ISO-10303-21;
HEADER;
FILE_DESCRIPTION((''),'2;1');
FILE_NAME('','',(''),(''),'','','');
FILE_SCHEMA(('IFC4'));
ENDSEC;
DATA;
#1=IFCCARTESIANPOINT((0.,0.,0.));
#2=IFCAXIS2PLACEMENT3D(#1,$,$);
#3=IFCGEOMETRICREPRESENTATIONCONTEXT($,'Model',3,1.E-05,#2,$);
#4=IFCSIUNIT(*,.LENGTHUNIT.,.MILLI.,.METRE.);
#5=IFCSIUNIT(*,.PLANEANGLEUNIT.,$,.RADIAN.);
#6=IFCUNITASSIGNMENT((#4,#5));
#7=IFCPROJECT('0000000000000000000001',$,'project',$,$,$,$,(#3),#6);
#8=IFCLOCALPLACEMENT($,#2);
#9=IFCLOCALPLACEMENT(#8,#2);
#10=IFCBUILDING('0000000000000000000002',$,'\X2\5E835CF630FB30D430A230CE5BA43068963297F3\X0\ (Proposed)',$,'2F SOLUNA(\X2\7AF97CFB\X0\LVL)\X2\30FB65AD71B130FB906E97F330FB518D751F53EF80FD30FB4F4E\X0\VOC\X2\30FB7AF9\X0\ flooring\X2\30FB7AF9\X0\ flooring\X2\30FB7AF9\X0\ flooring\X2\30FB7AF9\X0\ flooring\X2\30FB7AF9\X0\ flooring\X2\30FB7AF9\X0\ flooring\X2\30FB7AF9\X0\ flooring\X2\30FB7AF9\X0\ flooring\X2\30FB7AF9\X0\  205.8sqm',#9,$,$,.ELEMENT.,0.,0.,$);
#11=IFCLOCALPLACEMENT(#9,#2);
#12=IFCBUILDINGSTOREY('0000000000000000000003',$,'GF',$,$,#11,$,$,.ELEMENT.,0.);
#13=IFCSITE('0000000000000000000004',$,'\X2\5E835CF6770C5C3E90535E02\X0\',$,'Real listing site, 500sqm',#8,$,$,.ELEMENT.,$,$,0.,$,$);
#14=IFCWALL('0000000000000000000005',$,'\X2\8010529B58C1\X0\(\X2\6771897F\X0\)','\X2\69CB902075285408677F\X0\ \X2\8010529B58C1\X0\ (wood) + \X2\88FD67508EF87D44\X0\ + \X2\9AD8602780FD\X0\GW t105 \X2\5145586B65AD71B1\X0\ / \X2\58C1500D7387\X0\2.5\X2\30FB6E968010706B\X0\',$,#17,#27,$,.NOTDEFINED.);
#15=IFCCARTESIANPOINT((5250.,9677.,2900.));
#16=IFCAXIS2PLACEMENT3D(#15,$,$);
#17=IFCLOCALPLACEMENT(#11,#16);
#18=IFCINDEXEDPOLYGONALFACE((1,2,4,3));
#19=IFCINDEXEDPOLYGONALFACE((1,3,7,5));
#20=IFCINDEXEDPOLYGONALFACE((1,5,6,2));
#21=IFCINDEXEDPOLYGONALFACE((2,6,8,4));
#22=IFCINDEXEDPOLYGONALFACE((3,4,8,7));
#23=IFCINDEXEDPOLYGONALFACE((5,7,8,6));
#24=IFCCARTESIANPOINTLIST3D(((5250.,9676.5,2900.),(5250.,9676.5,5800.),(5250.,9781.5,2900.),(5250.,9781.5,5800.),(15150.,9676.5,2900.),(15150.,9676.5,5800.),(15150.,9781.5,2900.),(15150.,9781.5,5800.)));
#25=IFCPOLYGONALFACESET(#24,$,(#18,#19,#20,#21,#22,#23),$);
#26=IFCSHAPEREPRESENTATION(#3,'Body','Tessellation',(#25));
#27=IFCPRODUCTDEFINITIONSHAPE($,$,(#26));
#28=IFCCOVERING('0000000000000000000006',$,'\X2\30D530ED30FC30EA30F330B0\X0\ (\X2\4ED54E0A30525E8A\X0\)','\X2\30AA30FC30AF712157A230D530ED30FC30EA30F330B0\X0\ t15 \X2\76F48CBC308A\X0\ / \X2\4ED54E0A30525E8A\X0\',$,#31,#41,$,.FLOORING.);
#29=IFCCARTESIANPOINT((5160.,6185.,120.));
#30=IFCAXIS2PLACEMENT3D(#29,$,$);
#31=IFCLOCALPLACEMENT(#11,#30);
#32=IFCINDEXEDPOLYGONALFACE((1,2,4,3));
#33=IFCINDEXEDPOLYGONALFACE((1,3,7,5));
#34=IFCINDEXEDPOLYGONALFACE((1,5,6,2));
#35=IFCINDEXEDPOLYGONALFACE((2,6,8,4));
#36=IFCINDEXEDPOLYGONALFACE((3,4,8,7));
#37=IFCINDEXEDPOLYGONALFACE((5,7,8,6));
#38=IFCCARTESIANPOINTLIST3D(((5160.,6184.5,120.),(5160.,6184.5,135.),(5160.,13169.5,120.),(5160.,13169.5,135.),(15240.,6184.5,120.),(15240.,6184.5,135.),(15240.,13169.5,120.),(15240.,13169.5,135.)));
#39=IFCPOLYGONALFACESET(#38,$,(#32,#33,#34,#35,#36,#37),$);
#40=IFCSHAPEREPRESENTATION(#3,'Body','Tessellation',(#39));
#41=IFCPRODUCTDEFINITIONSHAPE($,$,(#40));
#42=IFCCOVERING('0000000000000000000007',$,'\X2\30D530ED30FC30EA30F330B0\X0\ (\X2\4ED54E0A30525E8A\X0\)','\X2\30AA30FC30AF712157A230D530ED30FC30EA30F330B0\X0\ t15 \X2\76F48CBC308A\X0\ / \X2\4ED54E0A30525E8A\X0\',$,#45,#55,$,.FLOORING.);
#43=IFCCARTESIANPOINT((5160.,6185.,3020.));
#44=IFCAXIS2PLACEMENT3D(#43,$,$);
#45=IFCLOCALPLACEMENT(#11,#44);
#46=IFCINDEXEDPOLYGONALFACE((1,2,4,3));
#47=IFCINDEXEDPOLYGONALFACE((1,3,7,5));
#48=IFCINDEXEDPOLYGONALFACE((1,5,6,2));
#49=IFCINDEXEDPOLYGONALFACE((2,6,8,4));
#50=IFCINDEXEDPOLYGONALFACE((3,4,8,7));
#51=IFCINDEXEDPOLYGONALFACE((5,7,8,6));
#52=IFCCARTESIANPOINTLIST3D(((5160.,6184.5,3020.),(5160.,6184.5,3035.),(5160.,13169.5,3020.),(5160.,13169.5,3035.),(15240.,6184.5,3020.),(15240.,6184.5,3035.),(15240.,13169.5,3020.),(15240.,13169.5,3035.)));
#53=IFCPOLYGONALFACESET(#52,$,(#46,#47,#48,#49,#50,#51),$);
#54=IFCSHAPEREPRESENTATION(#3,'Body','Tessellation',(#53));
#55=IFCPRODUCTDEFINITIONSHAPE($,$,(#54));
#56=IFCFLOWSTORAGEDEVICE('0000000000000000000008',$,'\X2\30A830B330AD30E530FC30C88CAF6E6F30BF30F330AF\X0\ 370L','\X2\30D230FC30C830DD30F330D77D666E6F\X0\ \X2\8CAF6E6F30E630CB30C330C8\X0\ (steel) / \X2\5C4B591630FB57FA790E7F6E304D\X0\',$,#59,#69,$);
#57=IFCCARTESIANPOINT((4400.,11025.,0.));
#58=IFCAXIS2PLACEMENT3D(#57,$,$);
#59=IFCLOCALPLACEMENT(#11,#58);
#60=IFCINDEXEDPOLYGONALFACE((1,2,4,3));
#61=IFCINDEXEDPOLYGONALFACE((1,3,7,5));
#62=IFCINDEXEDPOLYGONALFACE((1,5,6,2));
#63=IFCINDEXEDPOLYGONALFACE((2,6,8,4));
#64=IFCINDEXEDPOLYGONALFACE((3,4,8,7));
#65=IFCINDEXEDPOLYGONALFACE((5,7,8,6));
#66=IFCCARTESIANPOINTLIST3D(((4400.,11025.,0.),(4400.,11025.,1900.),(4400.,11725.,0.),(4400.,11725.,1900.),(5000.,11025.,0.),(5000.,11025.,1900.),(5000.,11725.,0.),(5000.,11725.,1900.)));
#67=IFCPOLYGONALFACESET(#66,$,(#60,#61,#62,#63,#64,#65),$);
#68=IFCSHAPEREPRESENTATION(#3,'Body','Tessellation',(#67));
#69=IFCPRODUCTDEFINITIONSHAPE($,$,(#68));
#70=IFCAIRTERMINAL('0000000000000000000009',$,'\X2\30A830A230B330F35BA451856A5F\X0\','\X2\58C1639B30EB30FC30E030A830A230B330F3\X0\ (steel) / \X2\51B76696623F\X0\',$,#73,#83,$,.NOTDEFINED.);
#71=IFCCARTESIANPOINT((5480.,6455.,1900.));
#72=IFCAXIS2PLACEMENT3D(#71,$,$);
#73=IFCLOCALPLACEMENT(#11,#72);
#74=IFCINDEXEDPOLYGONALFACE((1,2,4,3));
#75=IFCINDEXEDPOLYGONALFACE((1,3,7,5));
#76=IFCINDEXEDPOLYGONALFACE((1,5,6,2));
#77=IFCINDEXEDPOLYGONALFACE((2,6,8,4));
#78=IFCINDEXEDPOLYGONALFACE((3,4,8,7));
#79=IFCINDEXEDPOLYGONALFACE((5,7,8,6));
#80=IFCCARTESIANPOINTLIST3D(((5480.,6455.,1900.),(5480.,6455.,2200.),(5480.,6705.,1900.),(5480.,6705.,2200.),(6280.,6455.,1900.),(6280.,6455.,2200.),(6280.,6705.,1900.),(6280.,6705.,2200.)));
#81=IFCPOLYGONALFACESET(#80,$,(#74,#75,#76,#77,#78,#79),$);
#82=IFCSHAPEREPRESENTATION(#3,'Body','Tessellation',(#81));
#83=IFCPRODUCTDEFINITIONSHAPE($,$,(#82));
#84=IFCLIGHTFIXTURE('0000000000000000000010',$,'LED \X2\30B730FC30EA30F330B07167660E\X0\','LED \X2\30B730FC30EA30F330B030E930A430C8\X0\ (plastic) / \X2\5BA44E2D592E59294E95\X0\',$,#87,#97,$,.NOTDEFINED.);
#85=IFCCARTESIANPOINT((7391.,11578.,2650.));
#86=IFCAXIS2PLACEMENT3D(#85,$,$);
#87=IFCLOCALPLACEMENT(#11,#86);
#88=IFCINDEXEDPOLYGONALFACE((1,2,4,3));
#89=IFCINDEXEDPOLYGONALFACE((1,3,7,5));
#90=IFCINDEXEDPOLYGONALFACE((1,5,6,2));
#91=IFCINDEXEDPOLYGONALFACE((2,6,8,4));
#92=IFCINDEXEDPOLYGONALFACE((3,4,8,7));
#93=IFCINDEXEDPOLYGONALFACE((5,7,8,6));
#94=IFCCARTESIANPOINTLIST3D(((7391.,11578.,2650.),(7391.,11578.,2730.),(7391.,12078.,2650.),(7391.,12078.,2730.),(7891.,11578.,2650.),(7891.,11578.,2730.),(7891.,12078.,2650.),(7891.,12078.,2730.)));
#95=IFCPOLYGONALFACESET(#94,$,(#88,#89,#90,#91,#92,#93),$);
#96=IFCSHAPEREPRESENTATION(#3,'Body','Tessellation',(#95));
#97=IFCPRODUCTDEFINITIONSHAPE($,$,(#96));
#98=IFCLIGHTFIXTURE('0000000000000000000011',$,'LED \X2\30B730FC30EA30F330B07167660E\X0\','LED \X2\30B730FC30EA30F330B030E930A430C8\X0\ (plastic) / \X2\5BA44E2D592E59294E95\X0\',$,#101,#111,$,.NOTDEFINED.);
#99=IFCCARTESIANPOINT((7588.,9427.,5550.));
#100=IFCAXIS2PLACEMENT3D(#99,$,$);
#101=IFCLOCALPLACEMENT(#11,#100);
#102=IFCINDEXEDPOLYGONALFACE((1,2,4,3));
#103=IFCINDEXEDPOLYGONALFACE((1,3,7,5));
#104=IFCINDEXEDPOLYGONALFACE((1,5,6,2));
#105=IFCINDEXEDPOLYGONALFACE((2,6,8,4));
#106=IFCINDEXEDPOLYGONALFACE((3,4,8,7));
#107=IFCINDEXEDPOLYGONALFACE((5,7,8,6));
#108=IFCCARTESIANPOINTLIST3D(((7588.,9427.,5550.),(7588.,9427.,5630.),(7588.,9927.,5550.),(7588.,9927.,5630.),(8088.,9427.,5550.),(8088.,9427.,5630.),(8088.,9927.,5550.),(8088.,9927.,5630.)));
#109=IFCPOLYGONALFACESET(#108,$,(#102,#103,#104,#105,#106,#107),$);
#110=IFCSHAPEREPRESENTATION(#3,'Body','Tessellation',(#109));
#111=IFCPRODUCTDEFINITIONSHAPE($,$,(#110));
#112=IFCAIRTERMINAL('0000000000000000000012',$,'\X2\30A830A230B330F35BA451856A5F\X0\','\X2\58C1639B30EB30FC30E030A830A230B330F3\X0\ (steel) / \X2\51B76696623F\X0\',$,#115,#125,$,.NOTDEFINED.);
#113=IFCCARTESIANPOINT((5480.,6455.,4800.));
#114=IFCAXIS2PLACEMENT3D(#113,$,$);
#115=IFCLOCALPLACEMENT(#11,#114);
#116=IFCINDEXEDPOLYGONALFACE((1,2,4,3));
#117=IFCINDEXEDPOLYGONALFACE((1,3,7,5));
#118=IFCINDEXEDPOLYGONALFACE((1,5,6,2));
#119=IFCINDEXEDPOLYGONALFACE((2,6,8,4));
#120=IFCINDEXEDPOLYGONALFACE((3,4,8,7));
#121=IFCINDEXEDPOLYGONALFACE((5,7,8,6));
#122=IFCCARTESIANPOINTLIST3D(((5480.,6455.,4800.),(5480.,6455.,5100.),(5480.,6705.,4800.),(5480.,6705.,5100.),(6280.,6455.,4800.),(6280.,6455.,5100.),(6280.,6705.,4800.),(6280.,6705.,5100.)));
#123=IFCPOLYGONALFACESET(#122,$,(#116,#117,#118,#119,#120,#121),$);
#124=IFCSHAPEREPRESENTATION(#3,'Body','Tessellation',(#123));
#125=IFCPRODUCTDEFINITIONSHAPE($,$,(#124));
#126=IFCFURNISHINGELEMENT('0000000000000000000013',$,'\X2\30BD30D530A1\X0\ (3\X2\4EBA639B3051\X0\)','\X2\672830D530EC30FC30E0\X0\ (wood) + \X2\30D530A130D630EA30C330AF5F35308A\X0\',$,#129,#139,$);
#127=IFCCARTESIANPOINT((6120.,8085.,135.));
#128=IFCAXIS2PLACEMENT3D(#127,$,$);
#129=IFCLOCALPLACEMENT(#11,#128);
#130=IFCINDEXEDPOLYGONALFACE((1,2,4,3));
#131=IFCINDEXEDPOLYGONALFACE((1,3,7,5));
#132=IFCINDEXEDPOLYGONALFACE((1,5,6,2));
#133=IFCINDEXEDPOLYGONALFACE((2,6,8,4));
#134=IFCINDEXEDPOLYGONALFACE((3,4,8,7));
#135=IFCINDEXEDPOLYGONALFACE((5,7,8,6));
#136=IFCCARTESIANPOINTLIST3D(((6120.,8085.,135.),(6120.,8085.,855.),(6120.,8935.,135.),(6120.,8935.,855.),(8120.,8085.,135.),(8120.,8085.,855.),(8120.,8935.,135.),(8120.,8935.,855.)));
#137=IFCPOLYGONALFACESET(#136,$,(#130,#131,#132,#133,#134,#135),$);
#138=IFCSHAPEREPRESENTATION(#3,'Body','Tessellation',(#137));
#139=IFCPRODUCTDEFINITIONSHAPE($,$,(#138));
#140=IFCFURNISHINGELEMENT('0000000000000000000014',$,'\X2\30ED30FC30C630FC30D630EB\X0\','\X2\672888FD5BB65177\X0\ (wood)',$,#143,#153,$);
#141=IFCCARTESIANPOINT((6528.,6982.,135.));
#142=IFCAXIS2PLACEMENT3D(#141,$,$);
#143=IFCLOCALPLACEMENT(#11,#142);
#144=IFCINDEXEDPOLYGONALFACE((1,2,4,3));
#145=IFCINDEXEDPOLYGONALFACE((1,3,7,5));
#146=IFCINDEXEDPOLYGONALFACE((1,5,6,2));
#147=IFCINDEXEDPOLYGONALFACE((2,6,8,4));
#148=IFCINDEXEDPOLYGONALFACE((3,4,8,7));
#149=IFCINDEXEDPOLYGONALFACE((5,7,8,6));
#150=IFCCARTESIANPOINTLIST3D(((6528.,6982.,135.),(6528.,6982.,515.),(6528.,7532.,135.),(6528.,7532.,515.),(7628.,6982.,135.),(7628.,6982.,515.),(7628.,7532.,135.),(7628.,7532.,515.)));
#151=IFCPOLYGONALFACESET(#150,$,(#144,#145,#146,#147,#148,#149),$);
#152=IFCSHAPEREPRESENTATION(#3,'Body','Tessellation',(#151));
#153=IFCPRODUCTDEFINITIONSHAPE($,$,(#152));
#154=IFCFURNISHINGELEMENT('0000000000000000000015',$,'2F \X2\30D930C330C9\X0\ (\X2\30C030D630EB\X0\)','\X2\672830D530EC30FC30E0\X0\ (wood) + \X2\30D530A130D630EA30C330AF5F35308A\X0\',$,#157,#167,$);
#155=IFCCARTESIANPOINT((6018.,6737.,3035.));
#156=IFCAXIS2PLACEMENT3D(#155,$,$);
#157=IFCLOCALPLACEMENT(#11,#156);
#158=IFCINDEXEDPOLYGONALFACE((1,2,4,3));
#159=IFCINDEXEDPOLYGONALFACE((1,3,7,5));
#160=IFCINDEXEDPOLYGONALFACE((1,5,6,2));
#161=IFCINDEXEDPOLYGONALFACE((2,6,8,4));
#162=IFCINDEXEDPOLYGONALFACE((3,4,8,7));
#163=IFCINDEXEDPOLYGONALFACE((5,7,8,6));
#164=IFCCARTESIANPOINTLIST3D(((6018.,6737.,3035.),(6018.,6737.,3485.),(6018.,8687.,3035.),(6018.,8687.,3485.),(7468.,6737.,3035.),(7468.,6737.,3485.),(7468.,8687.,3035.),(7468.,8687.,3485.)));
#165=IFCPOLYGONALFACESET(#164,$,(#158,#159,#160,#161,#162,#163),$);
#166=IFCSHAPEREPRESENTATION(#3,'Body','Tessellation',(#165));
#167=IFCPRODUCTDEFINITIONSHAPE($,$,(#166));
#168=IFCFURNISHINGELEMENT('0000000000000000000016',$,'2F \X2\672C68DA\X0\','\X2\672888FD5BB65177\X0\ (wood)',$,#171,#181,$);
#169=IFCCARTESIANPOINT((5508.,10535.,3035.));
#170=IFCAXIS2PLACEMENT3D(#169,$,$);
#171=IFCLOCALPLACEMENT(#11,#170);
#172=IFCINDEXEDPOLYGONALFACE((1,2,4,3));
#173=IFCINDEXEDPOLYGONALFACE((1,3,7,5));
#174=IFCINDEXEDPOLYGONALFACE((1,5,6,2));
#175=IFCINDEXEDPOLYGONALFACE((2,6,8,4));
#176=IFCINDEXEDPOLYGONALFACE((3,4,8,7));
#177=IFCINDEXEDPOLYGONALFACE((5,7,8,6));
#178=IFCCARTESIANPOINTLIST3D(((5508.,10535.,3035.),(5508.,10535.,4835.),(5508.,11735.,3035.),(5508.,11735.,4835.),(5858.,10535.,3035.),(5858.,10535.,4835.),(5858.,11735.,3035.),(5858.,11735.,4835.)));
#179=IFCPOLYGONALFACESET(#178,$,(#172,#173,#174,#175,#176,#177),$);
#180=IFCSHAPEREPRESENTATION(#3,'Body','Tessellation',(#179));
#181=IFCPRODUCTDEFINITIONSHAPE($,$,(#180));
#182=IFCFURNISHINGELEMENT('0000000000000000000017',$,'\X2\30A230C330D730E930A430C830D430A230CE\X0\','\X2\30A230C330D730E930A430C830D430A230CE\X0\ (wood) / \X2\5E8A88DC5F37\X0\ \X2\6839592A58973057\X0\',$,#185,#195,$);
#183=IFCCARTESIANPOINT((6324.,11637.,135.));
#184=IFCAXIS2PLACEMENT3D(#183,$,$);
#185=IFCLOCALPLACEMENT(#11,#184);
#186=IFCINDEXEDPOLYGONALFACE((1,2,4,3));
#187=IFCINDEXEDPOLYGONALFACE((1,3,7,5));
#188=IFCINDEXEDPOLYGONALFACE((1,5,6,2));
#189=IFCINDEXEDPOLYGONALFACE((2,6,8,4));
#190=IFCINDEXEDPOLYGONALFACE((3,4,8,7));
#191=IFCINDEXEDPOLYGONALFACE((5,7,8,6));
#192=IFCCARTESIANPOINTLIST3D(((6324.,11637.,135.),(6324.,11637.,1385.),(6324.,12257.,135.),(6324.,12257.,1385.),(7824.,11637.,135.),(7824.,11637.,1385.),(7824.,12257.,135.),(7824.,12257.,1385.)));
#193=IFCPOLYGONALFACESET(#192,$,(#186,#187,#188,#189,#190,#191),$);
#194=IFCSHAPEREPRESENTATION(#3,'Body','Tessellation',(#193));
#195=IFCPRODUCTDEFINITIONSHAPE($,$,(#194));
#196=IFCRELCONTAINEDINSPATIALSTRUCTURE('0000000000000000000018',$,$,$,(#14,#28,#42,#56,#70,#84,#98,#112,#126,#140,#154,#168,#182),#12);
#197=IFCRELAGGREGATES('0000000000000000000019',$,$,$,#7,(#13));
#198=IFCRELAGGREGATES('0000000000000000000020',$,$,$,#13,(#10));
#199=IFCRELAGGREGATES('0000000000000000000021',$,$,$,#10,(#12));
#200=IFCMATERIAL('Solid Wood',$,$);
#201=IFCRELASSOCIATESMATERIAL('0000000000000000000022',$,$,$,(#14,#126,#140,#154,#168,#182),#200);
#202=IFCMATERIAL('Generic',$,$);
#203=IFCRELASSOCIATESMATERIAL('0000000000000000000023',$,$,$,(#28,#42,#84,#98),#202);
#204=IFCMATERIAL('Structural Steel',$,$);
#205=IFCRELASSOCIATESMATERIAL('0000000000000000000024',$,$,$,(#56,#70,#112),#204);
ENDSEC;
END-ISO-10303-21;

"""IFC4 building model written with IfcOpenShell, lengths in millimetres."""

from ifc_helpers import new_model, si_unit, frame, frame_2d, origin, place, context, project, spatial, rectangle, extrude, material, element, save


model = new_model("IFC4")

# Units and contexts
model_context = context("Model", 3, precision=1e-05, world=origin())
ifc_project = project(units=[si_unit("LENGTHUNIT", "METRE", prefix="MILLI"), si_unit("PLANEANGLEUNIT", "RADIAN")], contexts=[model_context])

# Site, building, storey
site_placement = place(None, origin())
site = spatial("IfcSite", under=ifc_project, at=site_placement, Name="広島県尾道市", ObjectType="Real listing site, 500sqm", CompositionType="ELEMENT", RefElevation=0.0)
building_placement = place(site_placement, origin())
building = spatial("IfcBuilding", under=site, at=building_placement, Name="広島・ピアノ室と防音 (Proposed)", ObjectType="2F SOLUNA(竹系LVL)・断熱・遮音・再生可能・低VOC・竹 flooring・竹 flooring・竹 flooring・竹 flooring・竹 flooring・竹 flooring・竹 flooring・竹 flooring・竹  205.8sqm", CompositionType="ELEMENT", ElevationOfRefHeight=0.0, ElevationOfTerrain=0.0)
storey_placement = place(building_placement, origin())
storey = spatial("IfcBuildingStorey", under=building, at=storey_placement, Name="GF", CompositionType="ELEMENT", Elevation=0.0)

# Shared definitions
ifc_material_1 = material(Name="Solid Wood")

# Wall
wall_1_placement = place(storey_placement, frame((5250.0, 9677.0, 2900.0)))
element("IfcWall", 1, at=wall_1_placement, inside=storey, material=ifc_material_1, Name="耐力壁(東西)", Description="構造用合板 耐力壁 (wood) + 製材軸組 + 高性能GW t105 充填断熱 / 壁倍率2.5・準耐火", PredefinedType="NOTDEFINED", context=model_context, shape_type="SweptSolid", body=[
    extrude(rectangle(XDim=9900.0, YDim=105.0, at=frame_2d((4950.0, 52.0))), frame((5250.0, 9677.0, 2900.0)), (0.0, 0.0, 1.0), 2900.0),
])

# Coverings
ifc_material_2 = material(Name="Generic")
covering_1_placement = place(storey_placement, frame((5160.0, 6185.0, 120.0)))
element("IfcCovering", 2, at=covering_1_placement, inside=storey, material=ifc_material_2, Name="フローリング (仕上げ床)", Description="オーク無垢フローリング t15 直貼り / 仕上げ床", PredefinedType="FLOORING", context=model_context, shape_type="SweptSolid", body=[
    extrude(rectangle(XDim=10080.0, YDim=6985.0, at=frame_2d((5040.0, 3492.0))), frame((5160.0, 6185.0, 120.0)), (0.0, 0.0, 1.0), 15.0),
])
covering_2_placement = place(storey_placement, frame((5160.0, 6185.0, 3020.0)))
element("IfcCovering", 3, at=covering_2_placement, inside=storey, material=ifc_material_2, Name="フローリング (仕上げ床)", Description="オーク無垢フローリング t15 直貼り / 仕上げ床", PredefinedType="FLOORING", context=model_context, shape_type="SweptSolid", body=[
    extrude(rectangle(XDim=10080.0, YDim=6985.0, at=frame_2d((5040.0, 3492.0))), frame((5160.0, 6185.0, 3020.0)), (0.0, 0.0, 1.0), 15.0),
])

# Flow storage device
ifc_material_3 = material(Name="Structural Steel")
flow_storage_device_placement = place(storey_placement, frame((4400.0, 11025.0, 0.0)))
element("IfcFlowStorageDevice", 4, at=flow_storage_device_placement, inside=storey, material=ifc_material_3, Name="エコキュート貯湯タンク 370L", Description="ヒートポンプ給湯 貯湯ユニット (steel) / 屋外・基礎置き", context=model_context, shape_type="SweptSolid", body=[
    extrude(rectangle(XDim=600.0, YDim=700.0, at=frame_2d((300.0, 350.0))), frame((4400.0, 11025.0, 0.0)), (0.0, 0.0, 1.0), 1900.0),
])

# Air terminal
air_terminal_1_placement = place(storey_placement, frame((5480.0, 6455.0, 1900.0)))
element("IfcAirTerminal", 5, at=air_terminal_1_placement, inside=storey, material=ifc_material_3, Name="エアコン室内機", Description="壁掛ルームエアコン (steel) / 冷暖房", PredefinedType="NOTDEFINED", context=model_context, shape_type="SweptSolid", body=[
    extrude(rectangle(XDim=800.0, YDim=250.0, at=frame_2d((400.0, 125.0))), frame((5480.0, 6455.0, 1900.0)), (0.0, 0.0, 1.0), 300.0),
])

# Light fixtures
light_fixture_1_placement = place(storey_placement, frame((7391.0, 11578.0, 2650.0)))
element("IfcLightFixture", 6, at=light_fixture_1_placement, inside=storey, material=ifc_material_2, Name="LED シーリング照明", Description="LED シーリングライト (plastic) / 室中央天井", PredefinedType="NOTDEFINED", context=model_context, shape_type="SweptSolid", body=[
    extrude(rectangle(XDim=500.0, YDim=500.0, at=frame_2d((250.0, 250.0))), frame((7391.0, 11578.0, 2650.0)), (0.0, 0.0, 1.0), 80.0),
])
light_fixture_2_placement = place(storey_placement, frame((7588.0, 9427.0, 5550.0)))
element("IfcLightFixture", 7, at=light_fixture_2_placement, inside=storey, material=ifc_material_2, Name="LED シーリング照明", Description="LED シーリングライト (plastic) / 室中央天井", PredefinedType="NOTDEFINED", context=model_context, shape_type="SweptSolid", body=[
    extrude(rectangle(XDim=500.0, YDim=500.0, at=frame_2d((250.0, 250.0))), frame((7588.0, 9427.0, 5550.0)), (0.0, 0.0, 1.0), 80.0),
])

# Air terminal
air_terminal_2_placement = place(storey_placement, frame((5480.0, 6455.0, 4800.0)))
element("IfcAirTerminal", 8, at=air_terminal_2_placement, inside=storey, material=ifc_material_3, Name="エアコン室内機", Description="壁掛ルームエアコン (steel) / 冷暖房", PredefinedType="NOTDEFINED", context=model_context, shape_type="SweptSolid", body=[
    extrude(rectangle(XDim=800.0, YDim=250.0, at=frame_2d((400.0, 125.0))), frame((5480.0, 6455.0, 4800.0)), (0.0, 0.0, 1.0), 300.0),
])

# Furnishing elements
furnishing_1_placement = place(storey_placement, frame((6120.0, 8085.0, 135.0)))
element("IfcFurnishingElement", 9, at=furnishing_1_placement, inside=storey, material=ifc_material_1, Name="ソファ (3人掛け)", Description="木フレーム (wood) + ファブリック張り", context=model_context, shape_type="SweptSolid", body=[
    extrude(rectangle(XDim=2000.0, YDim=850.0, at=frame_2d((1000.0, 425.0))), frame((6120.0, 8085.0, 135.0)), (0.0, 0.0, 1.0), 720.0),
])
furnishing_2_placement = place(storey_placement, frame((6528.0, 6982.0, 135.0)))
element("IfcFurnishingElement", 10, at=furnishing_2_placement, inside=storey, material=ifc_material_1, Name="ローテーブル", Description="木製家具 (wood)", context=model_context, shape_type="SweptSolid", body=[
    extrude(rectangle(XDim=1100.0, YDim=550.0, at=frame_2d((550.0, 275.0))), frame((6528.0, 6982.0, 135.0)), (0.0, 0.0, 1.0), 380.0),
])
furnishing_3_placement = place(storey_placement, frame((6018.0, 6737.0, 3035.0)))
element("IfcFurnishingElement", 11, at=furnishing_3_placement, inside=storey, material=ifc_material_1, Name="2F ベッド (ダブル)", Description="木フレーム (wood) + ファブリック張り", context=model_context, shape_type="SweptSolid", body=[
    extrude(rectangle(XDim=1450.0, YDim=1950.0, at=frame_2d((725.0, 975.0))), frame((6018.0, 6737.0, 3035.0)), (0.0, 0.0, 1.0), 450.0),
])
furnishing_4_placement = place(storey_placement, frame((5508.0, 10535.0, 3035.0)))
element("IfcFurnishingElement", 12, at=furnishing_4_placement, inside=storey, material=ifc_material_1, Name="2F 本棚", Description="木製家具 (wood)", context=model_context, shape_type="SweptSolid", body=[
    extrude(rectangle(XDim=350.0, YDim=1200.0, at=frame_2d((175.0, 600.0))), frame((5508.0, 10535.0, 3035.0)), (0.0, 0.0, 1.0), 1800.0),
])
furnishing_5_placement = place(storey_placement, frame((6324.0, 11637.0, 135.0)))
element("IfcFurnishingElement", 13, at=furnishing_5_placement, inside=storey, material=ifc_material_1, Name="アップライトピアノ", Description="アップライトピアノ (wood) / 床補強 根太増し", context=model_context, shape_type="SweptSolid", body=[
    extrude(rectangle(XDim=1500.0, YDim=620.0, at=frame_2d((750.0, 310.0))), frame((6324.0, 11637.0, 135.0)), (0.0, 0.0, 1.0), 1250.0),
])

save(model, "model.ifc")
